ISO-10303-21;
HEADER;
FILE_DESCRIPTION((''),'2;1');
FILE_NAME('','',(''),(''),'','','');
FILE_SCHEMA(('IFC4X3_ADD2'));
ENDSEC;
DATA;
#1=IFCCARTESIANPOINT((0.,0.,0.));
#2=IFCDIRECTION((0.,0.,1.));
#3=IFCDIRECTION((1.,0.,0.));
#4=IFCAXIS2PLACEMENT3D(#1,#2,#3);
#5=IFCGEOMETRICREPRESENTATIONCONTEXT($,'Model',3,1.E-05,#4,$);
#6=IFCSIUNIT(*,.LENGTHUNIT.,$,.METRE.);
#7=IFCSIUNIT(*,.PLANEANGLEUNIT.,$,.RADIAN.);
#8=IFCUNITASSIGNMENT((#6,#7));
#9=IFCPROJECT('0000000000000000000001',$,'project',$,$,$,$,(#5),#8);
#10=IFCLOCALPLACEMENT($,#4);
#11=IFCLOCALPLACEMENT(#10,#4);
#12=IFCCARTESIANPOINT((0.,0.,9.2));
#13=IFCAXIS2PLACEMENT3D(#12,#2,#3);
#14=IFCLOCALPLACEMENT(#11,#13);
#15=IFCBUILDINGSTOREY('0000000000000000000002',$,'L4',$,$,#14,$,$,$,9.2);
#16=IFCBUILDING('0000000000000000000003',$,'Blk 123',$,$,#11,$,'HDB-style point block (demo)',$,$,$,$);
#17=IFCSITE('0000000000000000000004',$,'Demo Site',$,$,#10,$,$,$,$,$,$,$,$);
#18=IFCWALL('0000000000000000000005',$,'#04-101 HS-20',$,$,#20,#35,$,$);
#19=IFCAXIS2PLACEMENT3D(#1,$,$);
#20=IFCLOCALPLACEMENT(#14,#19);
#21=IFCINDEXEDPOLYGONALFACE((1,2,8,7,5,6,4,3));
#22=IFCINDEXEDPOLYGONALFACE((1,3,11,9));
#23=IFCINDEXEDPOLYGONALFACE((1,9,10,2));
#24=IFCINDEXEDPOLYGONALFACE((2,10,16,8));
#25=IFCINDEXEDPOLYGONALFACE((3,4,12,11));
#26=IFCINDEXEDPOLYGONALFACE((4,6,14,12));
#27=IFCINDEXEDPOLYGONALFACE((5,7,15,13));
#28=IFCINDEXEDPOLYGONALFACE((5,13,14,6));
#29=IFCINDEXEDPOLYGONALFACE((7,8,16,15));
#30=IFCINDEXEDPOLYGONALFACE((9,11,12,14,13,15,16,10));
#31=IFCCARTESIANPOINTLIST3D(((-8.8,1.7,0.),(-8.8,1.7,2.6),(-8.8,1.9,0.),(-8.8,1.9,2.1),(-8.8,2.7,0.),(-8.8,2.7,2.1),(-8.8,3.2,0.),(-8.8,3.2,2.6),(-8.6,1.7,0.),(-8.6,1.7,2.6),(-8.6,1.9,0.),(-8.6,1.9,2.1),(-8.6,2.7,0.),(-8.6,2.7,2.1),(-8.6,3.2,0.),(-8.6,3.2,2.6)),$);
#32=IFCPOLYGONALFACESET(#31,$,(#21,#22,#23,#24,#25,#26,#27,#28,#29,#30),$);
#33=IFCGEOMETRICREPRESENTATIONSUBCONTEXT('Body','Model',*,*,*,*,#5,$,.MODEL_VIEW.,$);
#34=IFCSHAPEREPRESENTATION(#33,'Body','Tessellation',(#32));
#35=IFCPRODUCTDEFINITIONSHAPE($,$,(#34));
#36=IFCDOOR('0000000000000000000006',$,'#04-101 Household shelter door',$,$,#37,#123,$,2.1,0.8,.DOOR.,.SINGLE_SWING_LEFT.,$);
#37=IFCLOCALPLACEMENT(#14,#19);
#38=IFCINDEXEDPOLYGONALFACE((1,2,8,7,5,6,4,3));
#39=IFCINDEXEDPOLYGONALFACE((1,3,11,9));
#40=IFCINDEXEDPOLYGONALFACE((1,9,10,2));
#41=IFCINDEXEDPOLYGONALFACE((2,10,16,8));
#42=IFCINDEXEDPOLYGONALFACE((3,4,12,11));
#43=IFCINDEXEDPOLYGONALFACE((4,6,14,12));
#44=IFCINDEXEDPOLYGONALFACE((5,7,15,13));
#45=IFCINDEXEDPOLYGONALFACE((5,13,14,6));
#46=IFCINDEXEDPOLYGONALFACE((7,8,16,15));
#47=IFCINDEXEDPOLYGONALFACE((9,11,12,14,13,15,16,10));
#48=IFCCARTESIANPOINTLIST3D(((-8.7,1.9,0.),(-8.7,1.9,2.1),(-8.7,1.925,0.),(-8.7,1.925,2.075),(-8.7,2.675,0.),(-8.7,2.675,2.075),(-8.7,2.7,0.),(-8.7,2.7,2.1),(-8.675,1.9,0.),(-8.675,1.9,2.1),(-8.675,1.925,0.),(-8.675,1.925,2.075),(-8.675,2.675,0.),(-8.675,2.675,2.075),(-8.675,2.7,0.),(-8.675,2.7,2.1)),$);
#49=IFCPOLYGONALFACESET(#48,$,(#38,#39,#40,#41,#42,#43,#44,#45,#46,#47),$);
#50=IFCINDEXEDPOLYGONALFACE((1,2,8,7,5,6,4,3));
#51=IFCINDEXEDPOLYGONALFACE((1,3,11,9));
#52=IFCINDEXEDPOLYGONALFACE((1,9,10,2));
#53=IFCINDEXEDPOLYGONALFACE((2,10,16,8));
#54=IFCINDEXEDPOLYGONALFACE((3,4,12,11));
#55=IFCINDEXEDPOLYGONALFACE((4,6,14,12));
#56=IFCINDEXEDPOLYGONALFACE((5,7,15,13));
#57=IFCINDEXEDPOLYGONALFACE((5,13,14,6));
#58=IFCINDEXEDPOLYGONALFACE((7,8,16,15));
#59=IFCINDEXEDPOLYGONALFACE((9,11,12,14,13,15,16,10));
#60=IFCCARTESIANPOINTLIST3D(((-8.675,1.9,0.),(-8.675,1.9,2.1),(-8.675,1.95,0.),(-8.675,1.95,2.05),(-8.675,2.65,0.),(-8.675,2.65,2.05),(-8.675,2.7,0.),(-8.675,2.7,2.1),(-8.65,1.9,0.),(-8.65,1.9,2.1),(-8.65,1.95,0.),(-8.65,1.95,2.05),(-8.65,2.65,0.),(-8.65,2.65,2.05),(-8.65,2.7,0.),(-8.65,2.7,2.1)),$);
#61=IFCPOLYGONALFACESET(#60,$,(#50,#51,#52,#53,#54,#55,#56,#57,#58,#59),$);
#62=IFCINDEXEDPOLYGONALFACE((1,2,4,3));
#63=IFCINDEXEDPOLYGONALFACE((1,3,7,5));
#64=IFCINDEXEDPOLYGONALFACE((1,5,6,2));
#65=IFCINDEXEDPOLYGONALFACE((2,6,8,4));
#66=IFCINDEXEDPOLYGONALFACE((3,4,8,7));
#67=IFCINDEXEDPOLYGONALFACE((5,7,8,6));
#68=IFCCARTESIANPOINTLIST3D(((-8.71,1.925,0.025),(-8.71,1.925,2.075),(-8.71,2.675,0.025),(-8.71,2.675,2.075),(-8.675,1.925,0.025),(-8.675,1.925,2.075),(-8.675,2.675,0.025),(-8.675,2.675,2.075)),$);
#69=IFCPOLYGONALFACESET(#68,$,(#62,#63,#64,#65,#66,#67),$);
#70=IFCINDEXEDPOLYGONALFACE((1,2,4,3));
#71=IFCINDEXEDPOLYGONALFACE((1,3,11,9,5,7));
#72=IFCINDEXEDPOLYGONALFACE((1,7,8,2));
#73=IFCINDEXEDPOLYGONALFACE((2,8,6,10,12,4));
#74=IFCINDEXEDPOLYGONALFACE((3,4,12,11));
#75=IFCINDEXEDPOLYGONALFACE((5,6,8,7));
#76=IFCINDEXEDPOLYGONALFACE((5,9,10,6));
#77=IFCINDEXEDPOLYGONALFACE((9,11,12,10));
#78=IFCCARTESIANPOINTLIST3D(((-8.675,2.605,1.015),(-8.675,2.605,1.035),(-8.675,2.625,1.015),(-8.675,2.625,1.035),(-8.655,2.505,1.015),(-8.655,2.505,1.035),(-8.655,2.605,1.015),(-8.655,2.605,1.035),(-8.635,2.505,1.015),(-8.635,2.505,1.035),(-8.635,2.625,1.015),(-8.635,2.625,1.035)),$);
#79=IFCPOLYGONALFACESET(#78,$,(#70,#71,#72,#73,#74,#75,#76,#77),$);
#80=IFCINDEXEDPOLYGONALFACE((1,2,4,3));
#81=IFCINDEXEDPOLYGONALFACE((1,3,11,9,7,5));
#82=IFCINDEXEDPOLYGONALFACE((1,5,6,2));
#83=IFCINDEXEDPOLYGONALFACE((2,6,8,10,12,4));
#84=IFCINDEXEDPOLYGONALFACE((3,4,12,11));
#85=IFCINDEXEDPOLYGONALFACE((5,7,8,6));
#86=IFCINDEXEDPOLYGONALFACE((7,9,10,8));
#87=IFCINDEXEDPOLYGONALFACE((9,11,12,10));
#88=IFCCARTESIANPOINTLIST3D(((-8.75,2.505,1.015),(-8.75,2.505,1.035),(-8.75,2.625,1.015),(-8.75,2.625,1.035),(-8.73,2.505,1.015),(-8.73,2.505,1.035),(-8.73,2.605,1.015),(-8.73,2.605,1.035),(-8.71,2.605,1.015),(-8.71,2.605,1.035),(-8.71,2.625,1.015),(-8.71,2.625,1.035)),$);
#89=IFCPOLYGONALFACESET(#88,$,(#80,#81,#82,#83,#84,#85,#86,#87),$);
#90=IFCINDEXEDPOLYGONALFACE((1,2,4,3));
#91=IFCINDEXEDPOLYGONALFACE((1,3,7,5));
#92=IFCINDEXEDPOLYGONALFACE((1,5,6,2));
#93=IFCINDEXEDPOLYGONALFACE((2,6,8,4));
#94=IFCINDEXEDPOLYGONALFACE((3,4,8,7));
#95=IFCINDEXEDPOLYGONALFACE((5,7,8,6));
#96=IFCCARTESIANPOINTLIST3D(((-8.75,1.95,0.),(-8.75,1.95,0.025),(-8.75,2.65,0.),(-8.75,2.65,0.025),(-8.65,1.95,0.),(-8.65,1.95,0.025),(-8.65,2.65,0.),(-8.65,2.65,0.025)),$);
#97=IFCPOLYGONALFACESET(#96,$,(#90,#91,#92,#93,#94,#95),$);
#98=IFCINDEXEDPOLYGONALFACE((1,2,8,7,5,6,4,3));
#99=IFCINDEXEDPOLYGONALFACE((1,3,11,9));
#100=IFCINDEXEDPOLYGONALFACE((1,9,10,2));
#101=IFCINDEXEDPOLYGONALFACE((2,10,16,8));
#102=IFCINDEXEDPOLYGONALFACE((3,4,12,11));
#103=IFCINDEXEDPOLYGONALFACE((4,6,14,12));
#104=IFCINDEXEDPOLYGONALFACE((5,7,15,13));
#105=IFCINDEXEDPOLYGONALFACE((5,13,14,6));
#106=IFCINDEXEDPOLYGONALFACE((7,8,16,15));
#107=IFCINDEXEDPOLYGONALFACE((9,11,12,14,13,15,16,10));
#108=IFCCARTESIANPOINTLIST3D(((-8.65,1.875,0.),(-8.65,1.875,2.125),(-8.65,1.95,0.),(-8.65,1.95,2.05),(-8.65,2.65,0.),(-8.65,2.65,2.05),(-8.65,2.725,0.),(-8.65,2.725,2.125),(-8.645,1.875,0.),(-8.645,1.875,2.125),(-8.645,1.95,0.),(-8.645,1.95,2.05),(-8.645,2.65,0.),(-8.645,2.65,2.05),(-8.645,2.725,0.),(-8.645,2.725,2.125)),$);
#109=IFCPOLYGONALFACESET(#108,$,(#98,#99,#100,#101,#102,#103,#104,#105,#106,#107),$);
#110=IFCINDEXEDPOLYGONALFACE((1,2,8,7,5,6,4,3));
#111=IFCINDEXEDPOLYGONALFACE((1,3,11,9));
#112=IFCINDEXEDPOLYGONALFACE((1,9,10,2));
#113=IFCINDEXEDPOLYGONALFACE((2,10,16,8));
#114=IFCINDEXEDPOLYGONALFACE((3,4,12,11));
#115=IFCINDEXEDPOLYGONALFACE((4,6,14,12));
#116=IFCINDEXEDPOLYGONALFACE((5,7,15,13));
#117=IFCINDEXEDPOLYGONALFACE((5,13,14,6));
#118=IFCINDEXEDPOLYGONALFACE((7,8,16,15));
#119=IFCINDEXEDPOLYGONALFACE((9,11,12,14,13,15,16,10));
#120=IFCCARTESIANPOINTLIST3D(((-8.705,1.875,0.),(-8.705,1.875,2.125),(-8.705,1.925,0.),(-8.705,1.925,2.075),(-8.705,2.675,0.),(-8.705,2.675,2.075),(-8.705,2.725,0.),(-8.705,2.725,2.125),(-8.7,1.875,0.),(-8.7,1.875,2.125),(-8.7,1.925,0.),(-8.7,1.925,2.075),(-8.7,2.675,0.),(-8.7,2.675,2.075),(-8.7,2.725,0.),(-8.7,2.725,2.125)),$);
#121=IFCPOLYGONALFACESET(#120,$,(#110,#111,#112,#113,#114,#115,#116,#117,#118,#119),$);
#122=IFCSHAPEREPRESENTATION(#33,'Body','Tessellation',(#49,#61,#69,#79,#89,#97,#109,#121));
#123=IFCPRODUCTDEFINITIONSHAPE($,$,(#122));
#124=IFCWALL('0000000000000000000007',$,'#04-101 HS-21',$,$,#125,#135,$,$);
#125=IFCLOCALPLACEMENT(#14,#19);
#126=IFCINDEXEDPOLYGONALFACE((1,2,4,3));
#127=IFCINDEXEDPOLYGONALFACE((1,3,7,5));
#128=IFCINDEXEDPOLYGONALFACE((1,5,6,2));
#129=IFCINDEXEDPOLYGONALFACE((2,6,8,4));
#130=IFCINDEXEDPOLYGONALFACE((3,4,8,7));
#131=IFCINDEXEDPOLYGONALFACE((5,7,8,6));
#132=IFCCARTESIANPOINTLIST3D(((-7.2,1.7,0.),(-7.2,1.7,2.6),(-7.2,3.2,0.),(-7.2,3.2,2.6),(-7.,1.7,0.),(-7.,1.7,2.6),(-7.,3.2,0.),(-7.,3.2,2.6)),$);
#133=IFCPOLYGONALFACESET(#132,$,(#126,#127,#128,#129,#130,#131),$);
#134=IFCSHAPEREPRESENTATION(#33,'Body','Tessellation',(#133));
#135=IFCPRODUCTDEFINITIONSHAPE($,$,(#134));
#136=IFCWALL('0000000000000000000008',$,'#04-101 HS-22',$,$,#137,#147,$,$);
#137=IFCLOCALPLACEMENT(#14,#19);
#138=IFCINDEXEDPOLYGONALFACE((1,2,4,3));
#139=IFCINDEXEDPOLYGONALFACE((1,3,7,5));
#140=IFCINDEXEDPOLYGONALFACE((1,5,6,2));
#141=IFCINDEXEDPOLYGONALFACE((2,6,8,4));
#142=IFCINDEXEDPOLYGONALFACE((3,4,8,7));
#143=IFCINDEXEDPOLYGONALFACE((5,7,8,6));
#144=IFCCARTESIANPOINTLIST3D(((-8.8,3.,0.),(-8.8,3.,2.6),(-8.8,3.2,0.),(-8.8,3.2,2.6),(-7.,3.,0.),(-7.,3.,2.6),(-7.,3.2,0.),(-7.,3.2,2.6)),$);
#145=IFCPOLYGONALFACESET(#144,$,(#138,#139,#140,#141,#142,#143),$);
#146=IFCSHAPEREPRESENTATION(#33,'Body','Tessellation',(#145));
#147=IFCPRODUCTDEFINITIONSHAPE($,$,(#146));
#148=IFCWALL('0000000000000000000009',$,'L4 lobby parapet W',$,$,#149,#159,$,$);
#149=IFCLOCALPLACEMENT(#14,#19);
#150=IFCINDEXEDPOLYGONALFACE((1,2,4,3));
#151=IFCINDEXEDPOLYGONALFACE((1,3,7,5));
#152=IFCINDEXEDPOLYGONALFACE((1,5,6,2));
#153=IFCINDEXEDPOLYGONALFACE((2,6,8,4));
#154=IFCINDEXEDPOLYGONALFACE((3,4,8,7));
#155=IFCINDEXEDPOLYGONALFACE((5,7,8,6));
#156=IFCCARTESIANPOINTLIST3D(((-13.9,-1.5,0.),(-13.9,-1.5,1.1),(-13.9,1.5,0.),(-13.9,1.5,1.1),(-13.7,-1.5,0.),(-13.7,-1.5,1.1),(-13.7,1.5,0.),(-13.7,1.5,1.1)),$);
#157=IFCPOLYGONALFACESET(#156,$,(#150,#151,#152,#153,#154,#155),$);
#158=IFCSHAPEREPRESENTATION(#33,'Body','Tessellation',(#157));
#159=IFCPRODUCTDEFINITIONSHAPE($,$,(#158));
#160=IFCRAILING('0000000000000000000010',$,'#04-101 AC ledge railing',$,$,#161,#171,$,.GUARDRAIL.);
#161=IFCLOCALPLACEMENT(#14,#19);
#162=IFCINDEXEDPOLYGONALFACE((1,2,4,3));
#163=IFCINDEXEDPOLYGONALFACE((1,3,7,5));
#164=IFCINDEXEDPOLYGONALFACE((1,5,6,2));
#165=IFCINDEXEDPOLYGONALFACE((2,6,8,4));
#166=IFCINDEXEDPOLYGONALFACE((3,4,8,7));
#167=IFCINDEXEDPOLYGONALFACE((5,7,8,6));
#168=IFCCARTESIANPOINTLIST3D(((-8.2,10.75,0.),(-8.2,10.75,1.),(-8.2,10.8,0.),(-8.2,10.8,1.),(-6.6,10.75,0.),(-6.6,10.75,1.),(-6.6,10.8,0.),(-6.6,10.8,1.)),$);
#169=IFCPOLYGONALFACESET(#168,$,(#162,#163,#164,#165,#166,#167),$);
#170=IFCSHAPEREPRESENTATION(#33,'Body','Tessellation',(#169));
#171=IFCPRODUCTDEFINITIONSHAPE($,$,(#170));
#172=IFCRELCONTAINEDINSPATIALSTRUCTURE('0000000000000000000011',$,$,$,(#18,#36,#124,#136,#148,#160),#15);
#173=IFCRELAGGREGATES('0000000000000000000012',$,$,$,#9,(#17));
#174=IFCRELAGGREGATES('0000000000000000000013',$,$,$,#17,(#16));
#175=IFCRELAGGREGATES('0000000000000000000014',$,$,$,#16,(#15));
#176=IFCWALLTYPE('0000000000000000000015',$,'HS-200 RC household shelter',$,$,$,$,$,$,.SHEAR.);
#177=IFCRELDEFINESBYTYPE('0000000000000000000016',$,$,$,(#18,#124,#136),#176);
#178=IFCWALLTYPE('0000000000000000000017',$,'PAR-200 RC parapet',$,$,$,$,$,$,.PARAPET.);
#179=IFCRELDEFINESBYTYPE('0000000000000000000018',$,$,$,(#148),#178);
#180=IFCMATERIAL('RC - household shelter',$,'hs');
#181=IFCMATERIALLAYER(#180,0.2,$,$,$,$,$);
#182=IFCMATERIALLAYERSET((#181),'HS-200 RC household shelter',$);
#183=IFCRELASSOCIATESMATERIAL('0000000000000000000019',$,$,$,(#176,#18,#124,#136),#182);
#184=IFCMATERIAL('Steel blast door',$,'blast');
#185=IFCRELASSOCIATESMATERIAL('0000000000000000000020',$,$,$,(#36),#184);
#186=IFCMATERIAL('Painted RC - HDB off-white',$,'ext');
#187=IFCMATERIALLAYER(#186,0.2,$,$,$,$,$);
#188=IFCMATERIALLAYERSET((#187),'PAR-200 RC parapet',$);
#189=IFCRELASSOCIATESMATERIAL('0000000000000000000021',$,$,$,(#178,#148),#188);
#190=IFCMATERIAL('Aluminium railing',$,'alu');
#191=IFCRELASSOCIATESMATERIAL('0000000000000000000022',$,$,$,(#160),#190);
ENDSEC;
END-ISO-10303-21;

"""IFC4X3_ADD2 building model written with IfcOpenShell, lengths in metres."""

from ifc_helpers import new_model, si_unit, frame, origin, origin_with_axes, place, context, subcontext, project, spatial, polyline, line, indexed_curve, outline, extrude, material, layer, layer_set, layer_usage, type_object, element, fill, save


model = new_model("IFC4X3_ADD2")

# Units and contexts
model_context = context("Model", 3, precision=1e-05, world=origin_with_axes())
body_context = subcontext(model_context, "Body", "Model", "MODEL_VIEW")
ifc_project = project(units=[si_unit("LENGTHUNIT", "METRE"), si_unit("PLANEANGLEUNIT", "RADIAN")], contexts=[model_context])

# Site, building, storey
site_placement = place(None, origin_with_axes())
site = spatial("IfcSite", under=ifc_project, at=site_placement, Name="Demo Site")
building_placement = place(site_placement, origin_with_axes())
building = spatial("IfcBuilding", under=site, at=building_placement, Name="Blk 123", LongName="HDB-style point block (demo)")
storey_placement = place(building_placement, frame((0.0, 0.0, 9.2), z_axis=(0.0, 0.0, 1.0), x_axis=(1.0, 0.0, 0.0)))
storey = spatial("IfcBuildingStorey", under=building, at=storey_placement, Name="L4", Elevation=9.2)

# Shared definitions
ifc_material_1 = material(Name="Painted RC - HDB off-white", Category="ext")

# Wall, opening, door
ifc_material_2 = material(Name="RC - household shelter", Category="hs")
ifc_layer_1 = layer(ifc_material_2, 0.2)
ifc_layer_set_1 = layer_set([ifc_layer_1], Name="HS-200 RC household shelter")
ifc_layer_usage_1 = layer_usage(ifc_layer_set_1, "AXIS2", "POSITIVE", -0.1)
wall_type_1 = type_object("IfcWallType", Name="HS-200 RC household shelter", PredefinedType="SHEAR", material=ifc_layer_set_1)
wall_1_placement = place(storey_placement, frame((-8.7, 1.7, 0.0), z_axis=(0.0, 0.0, 1.0), x_axis=(0.0, 1.0, 0.0)))
wall_1 = element("IfcWall", 1, at=wall_1_placement, inside=storey, type_object=wall_type_1, material=ifc_layer_usage_1, Name="#04-101 HS-20", context=body_context, shape_type="SweptSolid", body=[
    extrude(outline(indexed_curve([(0.0, 0.0), (0.0, 0.2), (1.5, 0.2), (1.5, 0.0), (0.0, 0.0)], self_intersect=False)), frame((0.0, -0.1, 0.0), z_axis=(0.0, 0.0, 1.0), x_axis=(1.0, 0.0, 0.0)), (0.0, 0.0, 1.0), 2.6),
])
opening_1_placement = place(wall_1_placement, frame((0.2, -0.2, 0.0), z_axis=(0.0, 0.0, 1.0), x_axis=(1.0, 0.0, 0.0)))
opening_1 = element("IfcOpeningElement", 2, at=opening_1_placement, cuts=wall_1, context=body_context, shape_type="SweptSolid", body=[
    extrude(outline(indexed_curve([(0.0, 0.0), (0.0, 0.4), (0.8, 0.4), (0.8, 0.0), (0.0, 0.0)], self_intersect=False)), origin_with_axes(), (0.0, 0.0, 1.0), 2.1),
])
ifc_material_3 = material(Name="Steel blast door", Category="blast")
door_1_placement = place(opening_1_placement, frame((0.0, 0.15, 0.0), z_axis=(0.0, 0.0, 1.0), x_axis=(1.0, 0.0, 0.0)))
door_1 = element("IfcDoor", 3, at=door_1_placement, inside=storey, material=ifc_material_3, Name="#04-101 Household shelter door", OperationType="SINGLE_SWING_LEFT", OverallHeight=2.1, OverallWidth=0.8, PredefinedType="DOOR", context=body_context, shape_type="SweptSolid", body=[
    extrude(outline(indexed_curve([(0.0, 0.0), (0.0, 2.1), (0.8, 2.1), (0.8, 0.0), (0.775, 0.0), (0.775, 2.075), (0.025, 2.075), (0.025, 0.0)], segments=[line(1, 2, 3, 4, 5, 6, 7, 8, 1)])), frame((0.0, 0.025, 0.0), z_axis=(0.0, -1.0, 0.0), x_axis=(1.0, 0.0, 0.0)), (0.0, 0.0, -1.0), 0.025),
    extrude(outline(indexed_curve([(0.0, 0.0), (0.0, 2.1), (0.8, 2.1), (0.8, 0.0), (0.75, 0.0), (0.75, 2.05), (0.05, 2.05), (0.05, 0.0)], segments=[line(1, 2, 3, 4, 5, 6, 7, 8, 1)])), frame((0.0, 0.0, 0.0), z_axis=(0.0, -1.0, 0.0), x_axis=(1.0, 0.0, 0.0)), (0.0, 0.0, -1.0), 0.025),
    extrude(outline(indexed_curve([(0.0, 0.0), (0.75, 0.0), (0.75, 0.035), (0.0, 0.035)], segments=[line(1, 2, 3, 4, 1)])), frame((0.025, 0.025, 0.025), z_axis=(0.0, 0.0, 1.0), x_axis=(1.0, 0.0, 0.0)), (0.0, 0.0, 1.0), 2.05),
    extrude(outline(indexed_curve([(0.0, 0.0), (0.0, -0.04), (-0.12, -0.04), (-0.12, -0.02), (-0.02, -0.02), (-0.02, 0.0)], segments=[line(1, 2, 3, 4, 5, 6, 1)])), frame((0.725, 0.025, 1.015), z_axis=(0.0, 0.0, 1.0), x_axis=(1.0, 0.0, 0.0)), (0.0, 0.0, 1.0), 0.02),
    extrude(outline(indexed_curve([(0.0, 0.0), (0.0, 0.04), (-0.12, 0.04), (-0.12, 0.02), (-0.02, 0.02), (-0.02, 0.0)], segments=[line(1, 2, 3, 4, 5, 6, 1)])), frame((0.725, 0.06, 1.015), z_axis=(0.0, 0.0, 1.0), x_axis=(1.0, 0.0, 0.0)), (0.0, 0.0, 1.0), 0.02),
    extrude(outline(indexed_curve([(0.0, 0.0), (0.7, 0.0), (0.7, 0.1), (0.0, 0.1)], segments=[line(1, 2, 3, 4, 1)])), frame((0.05, 0.0, 0.0), z_axis=(0.0, 0.0, 1.0), x_axis=(1.0, 0.0, 0.0)), (0.0, 0.0, 1.0), 0.025),
    extrude(outline(indexed_curve([(0.0, 0.0), (0.0, 2.125), (0.85, 2.125), (0.85, 0.0), (0.775, 0.0), (0.775, 2.05), (0.075, 2.05), (0.075, 0.0)], segments=[line(1, 2, 3, 4, 5, 6, 7, 8, 1)])), frame((-0.025, -0.005, 0.0), z_axis=(0.0, -1.0, 0.0), x_axis=(1.0, 0.0, 0.0)), (0.0, 0.0, -1.0), 0.005),
    extrude(outline(indexed_curve([(0.0, 0.0), (0.0, 2.125), (0.85, 2.125), (0.85, 0.0), (0.8, 0.0), (0.8, 2.075), (0.05, 2.075), (0.05, 0.0)], segments=[line(1, 2, 3, 4, 5, 6, 7, 8, 1)])), frame((-0.025, 0.05, 0.0), z_axis=(0.0, -1.0, 0.0), x_axis=(1.0, 0.0, 0.0)), (0.0, 0.0, -1.0), 0.005),
])
fill(opening_1, door_1)

# Walls
wall_2_placement = place(storey_placement, frame((-7.1, 1.7, 0.0), z_axis=(0.0, 0.0, 1.0), x_axis=(0.0, 1.0, 0.0)))
element("IfcWall", 4, at=wall_2_placement, inside=storey, type_object=wall_type_1, material=ifc_layer_usage_1, Name="#04-101 HS-21", context=body_context, shape_type="SweptSolid", body=[
    extrude(outline(indexed_curve([(0.0, 0.0), (0.0, 0.2), (1.5, 0.2), (1.5, 0.0), (0.0, 0.0)], self_intersect=False)), frame((0.0, -0.1, 0.0), z_axis=(0.0, 0.0, 1.0), x_axis=(1.0, 0.0, 0.0)), (0.0, 0.0, 1.0), 2.6),
])
wall_3_placement = place(storey_placement, frame((-7.0, 3.1, 0.0), z_axis=(0.0, 0.0, 1.0), x_axis=(-1.0, 0.0, 0.0)))
element("IfcWall", 5, at=wall_3_placement, inside=storey, type_object=wall_type_1, material=ifc_layer_usage_1, Name="#04-101 HS-22", context=body_context, shape_type="SweptSolid", body=[
    extrude(outline(indexed_curve([(0.0, 0.0), (0.0, 0.2), (1.8, 0.2), (1.8, 0.0), (0.0, 0.0)], self_intersect=False)), frame((0.0, -0.1, 0.0), z_axis=(0.0, 0.0, 1.0), x_axis=(1.0, 0.0, 0.0)), (0.0, 0.0, 1.0), 2.6),
])
ifc_layer_2 = layer(ifc_material_1, 0.2)
ifc_layer_set_2 = layer_set([ifc_layer_2], Name="PAR-200 RC parapet")
ifc_layer_usage_2 = layer_usage(ifc_layer_set_2, "AXIS2", "POSITIVE", 0.0)
wall_type_2 = type_object("IfcWallType", Name="PAR-200 RC parapet", PredefinedType="PARAPET", material=ifc_layer_set_2)
wall_4_placement = place(storey_placement, frame((-13.9, 1.5, 0.0), z_axis=(0.0, 0.0, 1.0), x_axis=(0.0, -1.0, 0.0)))
element("IfcWall", 6, at=wall_4_placement, inside=storey, type_object=wall_type_2, material=ifc_layer_usage_2, Name="L4 lobby parapet W", context=body_context, shape_type="SweptSolid", body=[
    extrude(outline(indexed_curve([(0.0, 0.0), (0.0, 0.2), (3.0, 0.2), (3.0, 0.0), (0.0, 0.0)], self_intersect=False)), origin_with_axes(), (0.0, 0.0, 1.0), 1.1),
])

# Railing
ifc_material_4 = material(Name="Aluminium railing", Category="alu")
railing_placement = place(storey_placement, frame((-7.4, 10.775, 0.0), z_axis=(0.0, 0.0, 1.0), x_axis=(1.0, 0.0, 0.0)))
element("IfcRailing", 7, at=railing_placement, inside=storey, material=ifc_material_4, Name="#04-101 AC ledge railing", PredefinedType="GUARDRAIL", context=body_context, shape_type="SweptSolid", body=[
    extrude(outline(polyline([(-0.8, -0.025), (0.8, -0.025), (0.8, 0.025), (-0.8, 0.025), (-0.8, -0.025)])), origin(), (0.0, 0.0, 1.0), 1.0),
])

save(model, "model.ifc")
